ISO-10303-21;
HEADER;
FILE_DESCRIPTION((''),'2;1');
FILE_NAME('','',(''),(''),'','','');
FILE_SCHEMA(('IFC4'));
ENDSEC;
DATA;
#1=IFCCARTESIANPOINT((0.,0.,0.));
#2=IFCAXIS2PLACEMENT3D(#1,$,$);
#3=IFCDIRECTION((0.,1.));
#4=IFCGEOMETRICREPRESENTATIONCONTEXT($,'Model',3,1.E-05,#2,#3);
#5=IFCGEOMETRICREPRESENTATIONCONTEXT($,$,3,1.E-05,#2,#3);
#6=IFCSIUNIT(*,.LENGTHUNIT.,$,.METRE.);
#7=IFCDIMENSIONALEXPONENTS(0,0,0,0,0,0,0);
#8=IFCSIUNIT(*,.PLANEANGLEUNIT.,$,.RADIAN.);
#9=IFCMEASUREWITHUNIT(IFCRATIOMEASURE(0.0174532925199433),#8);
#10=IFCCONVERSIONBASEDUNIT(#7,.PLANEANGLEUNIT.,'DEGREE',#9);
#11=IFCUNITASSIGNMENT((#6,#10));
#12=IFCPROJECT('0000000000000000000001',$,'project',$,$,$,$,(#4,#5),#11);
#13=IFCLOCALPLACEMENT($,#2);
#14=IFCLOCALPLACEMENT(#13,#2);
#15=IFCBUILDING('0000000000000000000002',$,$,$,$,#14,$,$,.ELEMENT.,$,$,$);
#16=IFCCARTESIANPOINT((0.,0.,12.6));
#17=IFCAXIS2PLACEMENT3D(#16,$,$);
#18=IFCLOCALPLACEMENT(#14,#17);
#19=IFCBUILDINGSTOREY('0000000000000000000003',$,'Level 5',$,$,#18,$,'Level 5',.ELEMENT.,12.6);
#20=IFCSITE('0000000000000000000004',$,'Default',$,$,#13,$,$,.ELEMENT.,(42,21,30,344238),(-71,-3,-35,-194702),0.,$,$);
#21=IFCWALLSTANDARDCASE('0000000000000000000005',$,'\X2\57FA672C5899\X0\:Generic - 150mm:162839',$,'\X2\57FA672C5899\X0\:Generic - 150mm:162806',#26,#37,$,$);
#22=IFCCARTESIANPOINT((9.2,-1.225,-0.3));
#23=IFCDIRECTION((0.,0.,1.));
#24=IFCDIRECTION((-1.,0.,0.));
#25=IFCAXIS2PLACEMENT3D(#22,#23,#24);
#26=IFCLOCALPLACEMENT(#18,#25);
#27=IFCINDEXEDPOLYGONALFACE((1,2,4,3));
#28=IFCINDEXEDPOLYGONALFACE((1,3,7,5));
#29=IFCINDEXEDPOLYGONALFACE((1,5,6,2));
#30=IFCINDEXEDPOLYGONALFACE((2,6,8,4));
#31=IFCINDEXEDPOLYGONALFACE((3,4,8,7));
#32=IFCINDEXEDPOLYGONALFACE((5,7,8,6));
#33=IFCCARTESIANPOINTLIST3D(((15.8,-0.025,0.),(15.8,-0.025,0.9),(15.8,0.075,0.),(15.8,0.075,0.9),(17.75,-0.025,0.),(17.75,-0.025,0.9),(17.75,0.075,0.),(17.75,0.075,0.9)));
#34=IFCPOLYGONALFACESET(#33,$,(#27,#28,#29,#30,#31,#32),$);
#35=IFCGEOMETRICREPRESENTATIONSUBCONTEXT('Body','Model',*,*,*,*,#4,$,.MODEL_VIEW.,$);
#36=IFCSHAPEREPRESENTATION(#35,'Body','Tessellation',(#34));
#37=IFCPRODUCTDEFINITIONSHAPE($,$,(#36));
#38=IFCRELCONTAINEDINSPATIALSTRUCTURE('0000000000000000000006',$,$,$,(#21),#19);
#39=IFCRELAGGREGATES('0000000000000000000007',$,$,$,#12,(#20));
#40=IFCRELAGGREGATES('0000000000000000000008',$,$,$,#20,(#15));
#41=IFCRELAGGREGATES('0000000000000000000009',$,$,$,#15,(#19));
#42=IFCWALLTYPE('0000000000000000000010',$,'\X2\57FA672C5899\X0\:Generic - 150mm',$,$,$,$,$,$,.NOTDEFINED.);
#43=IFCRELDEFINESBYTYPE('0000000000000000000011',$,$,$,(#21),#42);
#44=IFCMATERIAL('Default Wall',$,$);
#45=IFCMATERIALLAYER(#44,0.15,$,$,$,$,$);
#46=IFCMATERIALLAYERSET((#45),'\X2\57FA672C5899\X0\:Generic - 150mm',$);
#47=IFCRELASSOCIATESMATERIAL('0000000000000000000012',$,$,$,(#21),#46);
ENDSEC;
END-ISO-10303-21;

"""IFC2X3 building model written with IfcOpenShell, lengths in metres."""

from ifc_helpers import new_model, entity, si_unit, converted_unit, direction, frame, frame_2d, origin, place, context, subcontext, project, spatial, polyline, rectangle, extrude, clip, bounded_halfspace, material, layer, layer_set, layer_usage, type_object, element, save


model = new_model("IFC2X3")

# Units and contexts
model_context = context("Model", 3, precision=1e-05, world=origin(), true_north=direction((0.0, 1.0)))
context_of_model = context(None, 3, precision=1e-05, world=origin(), true_north=direction((0.0, 1.0)))
body_context = subcontext(model_context, "Body", "Model", "MODEL_VIEW")
ifc_project = project(units=[si_unit("LENGTHUNIT", "METRE"), converted_unit("PLANEANGLEUNIT", "DEGREE", entity("IfcRatioMeasure", 0.0174532925199433), si_unit("PLANEANGLEUNIT", "RADIAN"), dimensions=[0, 0, 0, 0, 0, 0, 0])], contexts=[model_context, context_of_model])

# Site, building, storey
site_placement = place(None, origin())
site = spatial("IfcSite", under=ifc_project, at=site_placement, Name="Default", CompositionType="ELEMENT", RefLatitude=(42, 21, 30, 344238), RefLongitude=(-71, -3, -35, -194702), RefElevation=0.0)
building_placement = place(site_placement, origin())
building = spatial("IfcBuilding", under=site, at=building_placement, CompositionType="ELEMENT")
storey_placement = place(building_placement, frame((0.0, 0.0, 12.6)))
storey = spatial("IfcBuildingStorey", under=building, at=storey_placement, Name="Level 5", LongName="Level 5", CompositionType="ELEMENT", Elevation=12.6)

# Wall
ifc_material_1 = material(Name="Default Wall")
ifc_layer_1 = layer(ifc_material_1, 0.15)
ifc_layer_set_1 = layer_set([ifc_layer_1], Name="基本墙:Generic - 150mm")
ifc_layer_usage_1 = layer_usage(ifc_layer_set_1, "AXIS2", "NEGATIVE", 0.075)
wall_type = type_object("IfcWallType", Name="基本墙:Generic - 150mm", PredefinedType="NOTDEFINED")
wall_1_placement = place(storey_placement, frame((9.2, -1.225, -0.3), z_axis=(0.0, 0.0, 1.0), x_axis=(-1.0, 0.0, 0.0)))
element("IfcWallStandardCase", 1, at=wall_1_placement, inside=storey, type_object=wall_type, material=ifc_layer_usage_1, Name="基本墙:Generic - 150mm:162839", ObjectType="基本墙:Generic - 150mm:162806", context=body_context, shape_type="Clipping", body=[
    clip(clip(extrude(rectangle(XDim=0.1, YDim=1.95, at=frame_2d((16.775, 0.025), x_axis=(0.0, -1.0))), origin(), (0.0, 0.0, 1.0), 0.9), bounded_halfspace(frame((17.75, -0.025, 0.0), z_axis=(0.0, 1.0, 0.0), x_axis=(0.0, 0.0, 1.0)), True, frame((17.75, -0.025, 0.0), z_axis=(0.0, 1.0, 0.0), x_axis=(0.0, 0.0, 1.0)), polyline([(0.0, 0.0), (0.0, -1.95), (0.3, -1.95), (0.3, 0.0), (0.0, 0.0)]))), bounded_halfspace(frame((15.8, -0.025, 0.3), z_axis=(1.0, 0.0, 0.0), x_axis=(0.0, 1.0, 0.0)), True, frame((15.8, -0.025, 0.3), z_axis=(1.0, 0.0, 0.0), x_axis=(0.0, 1.0, 0.0)), polyline([(0.0, 0.0), (0.0, -0.3), (0.1, -0.3), (0.1, 0.0), (0.0, 0.0)]))),
])

save(model, "model.ifc")
